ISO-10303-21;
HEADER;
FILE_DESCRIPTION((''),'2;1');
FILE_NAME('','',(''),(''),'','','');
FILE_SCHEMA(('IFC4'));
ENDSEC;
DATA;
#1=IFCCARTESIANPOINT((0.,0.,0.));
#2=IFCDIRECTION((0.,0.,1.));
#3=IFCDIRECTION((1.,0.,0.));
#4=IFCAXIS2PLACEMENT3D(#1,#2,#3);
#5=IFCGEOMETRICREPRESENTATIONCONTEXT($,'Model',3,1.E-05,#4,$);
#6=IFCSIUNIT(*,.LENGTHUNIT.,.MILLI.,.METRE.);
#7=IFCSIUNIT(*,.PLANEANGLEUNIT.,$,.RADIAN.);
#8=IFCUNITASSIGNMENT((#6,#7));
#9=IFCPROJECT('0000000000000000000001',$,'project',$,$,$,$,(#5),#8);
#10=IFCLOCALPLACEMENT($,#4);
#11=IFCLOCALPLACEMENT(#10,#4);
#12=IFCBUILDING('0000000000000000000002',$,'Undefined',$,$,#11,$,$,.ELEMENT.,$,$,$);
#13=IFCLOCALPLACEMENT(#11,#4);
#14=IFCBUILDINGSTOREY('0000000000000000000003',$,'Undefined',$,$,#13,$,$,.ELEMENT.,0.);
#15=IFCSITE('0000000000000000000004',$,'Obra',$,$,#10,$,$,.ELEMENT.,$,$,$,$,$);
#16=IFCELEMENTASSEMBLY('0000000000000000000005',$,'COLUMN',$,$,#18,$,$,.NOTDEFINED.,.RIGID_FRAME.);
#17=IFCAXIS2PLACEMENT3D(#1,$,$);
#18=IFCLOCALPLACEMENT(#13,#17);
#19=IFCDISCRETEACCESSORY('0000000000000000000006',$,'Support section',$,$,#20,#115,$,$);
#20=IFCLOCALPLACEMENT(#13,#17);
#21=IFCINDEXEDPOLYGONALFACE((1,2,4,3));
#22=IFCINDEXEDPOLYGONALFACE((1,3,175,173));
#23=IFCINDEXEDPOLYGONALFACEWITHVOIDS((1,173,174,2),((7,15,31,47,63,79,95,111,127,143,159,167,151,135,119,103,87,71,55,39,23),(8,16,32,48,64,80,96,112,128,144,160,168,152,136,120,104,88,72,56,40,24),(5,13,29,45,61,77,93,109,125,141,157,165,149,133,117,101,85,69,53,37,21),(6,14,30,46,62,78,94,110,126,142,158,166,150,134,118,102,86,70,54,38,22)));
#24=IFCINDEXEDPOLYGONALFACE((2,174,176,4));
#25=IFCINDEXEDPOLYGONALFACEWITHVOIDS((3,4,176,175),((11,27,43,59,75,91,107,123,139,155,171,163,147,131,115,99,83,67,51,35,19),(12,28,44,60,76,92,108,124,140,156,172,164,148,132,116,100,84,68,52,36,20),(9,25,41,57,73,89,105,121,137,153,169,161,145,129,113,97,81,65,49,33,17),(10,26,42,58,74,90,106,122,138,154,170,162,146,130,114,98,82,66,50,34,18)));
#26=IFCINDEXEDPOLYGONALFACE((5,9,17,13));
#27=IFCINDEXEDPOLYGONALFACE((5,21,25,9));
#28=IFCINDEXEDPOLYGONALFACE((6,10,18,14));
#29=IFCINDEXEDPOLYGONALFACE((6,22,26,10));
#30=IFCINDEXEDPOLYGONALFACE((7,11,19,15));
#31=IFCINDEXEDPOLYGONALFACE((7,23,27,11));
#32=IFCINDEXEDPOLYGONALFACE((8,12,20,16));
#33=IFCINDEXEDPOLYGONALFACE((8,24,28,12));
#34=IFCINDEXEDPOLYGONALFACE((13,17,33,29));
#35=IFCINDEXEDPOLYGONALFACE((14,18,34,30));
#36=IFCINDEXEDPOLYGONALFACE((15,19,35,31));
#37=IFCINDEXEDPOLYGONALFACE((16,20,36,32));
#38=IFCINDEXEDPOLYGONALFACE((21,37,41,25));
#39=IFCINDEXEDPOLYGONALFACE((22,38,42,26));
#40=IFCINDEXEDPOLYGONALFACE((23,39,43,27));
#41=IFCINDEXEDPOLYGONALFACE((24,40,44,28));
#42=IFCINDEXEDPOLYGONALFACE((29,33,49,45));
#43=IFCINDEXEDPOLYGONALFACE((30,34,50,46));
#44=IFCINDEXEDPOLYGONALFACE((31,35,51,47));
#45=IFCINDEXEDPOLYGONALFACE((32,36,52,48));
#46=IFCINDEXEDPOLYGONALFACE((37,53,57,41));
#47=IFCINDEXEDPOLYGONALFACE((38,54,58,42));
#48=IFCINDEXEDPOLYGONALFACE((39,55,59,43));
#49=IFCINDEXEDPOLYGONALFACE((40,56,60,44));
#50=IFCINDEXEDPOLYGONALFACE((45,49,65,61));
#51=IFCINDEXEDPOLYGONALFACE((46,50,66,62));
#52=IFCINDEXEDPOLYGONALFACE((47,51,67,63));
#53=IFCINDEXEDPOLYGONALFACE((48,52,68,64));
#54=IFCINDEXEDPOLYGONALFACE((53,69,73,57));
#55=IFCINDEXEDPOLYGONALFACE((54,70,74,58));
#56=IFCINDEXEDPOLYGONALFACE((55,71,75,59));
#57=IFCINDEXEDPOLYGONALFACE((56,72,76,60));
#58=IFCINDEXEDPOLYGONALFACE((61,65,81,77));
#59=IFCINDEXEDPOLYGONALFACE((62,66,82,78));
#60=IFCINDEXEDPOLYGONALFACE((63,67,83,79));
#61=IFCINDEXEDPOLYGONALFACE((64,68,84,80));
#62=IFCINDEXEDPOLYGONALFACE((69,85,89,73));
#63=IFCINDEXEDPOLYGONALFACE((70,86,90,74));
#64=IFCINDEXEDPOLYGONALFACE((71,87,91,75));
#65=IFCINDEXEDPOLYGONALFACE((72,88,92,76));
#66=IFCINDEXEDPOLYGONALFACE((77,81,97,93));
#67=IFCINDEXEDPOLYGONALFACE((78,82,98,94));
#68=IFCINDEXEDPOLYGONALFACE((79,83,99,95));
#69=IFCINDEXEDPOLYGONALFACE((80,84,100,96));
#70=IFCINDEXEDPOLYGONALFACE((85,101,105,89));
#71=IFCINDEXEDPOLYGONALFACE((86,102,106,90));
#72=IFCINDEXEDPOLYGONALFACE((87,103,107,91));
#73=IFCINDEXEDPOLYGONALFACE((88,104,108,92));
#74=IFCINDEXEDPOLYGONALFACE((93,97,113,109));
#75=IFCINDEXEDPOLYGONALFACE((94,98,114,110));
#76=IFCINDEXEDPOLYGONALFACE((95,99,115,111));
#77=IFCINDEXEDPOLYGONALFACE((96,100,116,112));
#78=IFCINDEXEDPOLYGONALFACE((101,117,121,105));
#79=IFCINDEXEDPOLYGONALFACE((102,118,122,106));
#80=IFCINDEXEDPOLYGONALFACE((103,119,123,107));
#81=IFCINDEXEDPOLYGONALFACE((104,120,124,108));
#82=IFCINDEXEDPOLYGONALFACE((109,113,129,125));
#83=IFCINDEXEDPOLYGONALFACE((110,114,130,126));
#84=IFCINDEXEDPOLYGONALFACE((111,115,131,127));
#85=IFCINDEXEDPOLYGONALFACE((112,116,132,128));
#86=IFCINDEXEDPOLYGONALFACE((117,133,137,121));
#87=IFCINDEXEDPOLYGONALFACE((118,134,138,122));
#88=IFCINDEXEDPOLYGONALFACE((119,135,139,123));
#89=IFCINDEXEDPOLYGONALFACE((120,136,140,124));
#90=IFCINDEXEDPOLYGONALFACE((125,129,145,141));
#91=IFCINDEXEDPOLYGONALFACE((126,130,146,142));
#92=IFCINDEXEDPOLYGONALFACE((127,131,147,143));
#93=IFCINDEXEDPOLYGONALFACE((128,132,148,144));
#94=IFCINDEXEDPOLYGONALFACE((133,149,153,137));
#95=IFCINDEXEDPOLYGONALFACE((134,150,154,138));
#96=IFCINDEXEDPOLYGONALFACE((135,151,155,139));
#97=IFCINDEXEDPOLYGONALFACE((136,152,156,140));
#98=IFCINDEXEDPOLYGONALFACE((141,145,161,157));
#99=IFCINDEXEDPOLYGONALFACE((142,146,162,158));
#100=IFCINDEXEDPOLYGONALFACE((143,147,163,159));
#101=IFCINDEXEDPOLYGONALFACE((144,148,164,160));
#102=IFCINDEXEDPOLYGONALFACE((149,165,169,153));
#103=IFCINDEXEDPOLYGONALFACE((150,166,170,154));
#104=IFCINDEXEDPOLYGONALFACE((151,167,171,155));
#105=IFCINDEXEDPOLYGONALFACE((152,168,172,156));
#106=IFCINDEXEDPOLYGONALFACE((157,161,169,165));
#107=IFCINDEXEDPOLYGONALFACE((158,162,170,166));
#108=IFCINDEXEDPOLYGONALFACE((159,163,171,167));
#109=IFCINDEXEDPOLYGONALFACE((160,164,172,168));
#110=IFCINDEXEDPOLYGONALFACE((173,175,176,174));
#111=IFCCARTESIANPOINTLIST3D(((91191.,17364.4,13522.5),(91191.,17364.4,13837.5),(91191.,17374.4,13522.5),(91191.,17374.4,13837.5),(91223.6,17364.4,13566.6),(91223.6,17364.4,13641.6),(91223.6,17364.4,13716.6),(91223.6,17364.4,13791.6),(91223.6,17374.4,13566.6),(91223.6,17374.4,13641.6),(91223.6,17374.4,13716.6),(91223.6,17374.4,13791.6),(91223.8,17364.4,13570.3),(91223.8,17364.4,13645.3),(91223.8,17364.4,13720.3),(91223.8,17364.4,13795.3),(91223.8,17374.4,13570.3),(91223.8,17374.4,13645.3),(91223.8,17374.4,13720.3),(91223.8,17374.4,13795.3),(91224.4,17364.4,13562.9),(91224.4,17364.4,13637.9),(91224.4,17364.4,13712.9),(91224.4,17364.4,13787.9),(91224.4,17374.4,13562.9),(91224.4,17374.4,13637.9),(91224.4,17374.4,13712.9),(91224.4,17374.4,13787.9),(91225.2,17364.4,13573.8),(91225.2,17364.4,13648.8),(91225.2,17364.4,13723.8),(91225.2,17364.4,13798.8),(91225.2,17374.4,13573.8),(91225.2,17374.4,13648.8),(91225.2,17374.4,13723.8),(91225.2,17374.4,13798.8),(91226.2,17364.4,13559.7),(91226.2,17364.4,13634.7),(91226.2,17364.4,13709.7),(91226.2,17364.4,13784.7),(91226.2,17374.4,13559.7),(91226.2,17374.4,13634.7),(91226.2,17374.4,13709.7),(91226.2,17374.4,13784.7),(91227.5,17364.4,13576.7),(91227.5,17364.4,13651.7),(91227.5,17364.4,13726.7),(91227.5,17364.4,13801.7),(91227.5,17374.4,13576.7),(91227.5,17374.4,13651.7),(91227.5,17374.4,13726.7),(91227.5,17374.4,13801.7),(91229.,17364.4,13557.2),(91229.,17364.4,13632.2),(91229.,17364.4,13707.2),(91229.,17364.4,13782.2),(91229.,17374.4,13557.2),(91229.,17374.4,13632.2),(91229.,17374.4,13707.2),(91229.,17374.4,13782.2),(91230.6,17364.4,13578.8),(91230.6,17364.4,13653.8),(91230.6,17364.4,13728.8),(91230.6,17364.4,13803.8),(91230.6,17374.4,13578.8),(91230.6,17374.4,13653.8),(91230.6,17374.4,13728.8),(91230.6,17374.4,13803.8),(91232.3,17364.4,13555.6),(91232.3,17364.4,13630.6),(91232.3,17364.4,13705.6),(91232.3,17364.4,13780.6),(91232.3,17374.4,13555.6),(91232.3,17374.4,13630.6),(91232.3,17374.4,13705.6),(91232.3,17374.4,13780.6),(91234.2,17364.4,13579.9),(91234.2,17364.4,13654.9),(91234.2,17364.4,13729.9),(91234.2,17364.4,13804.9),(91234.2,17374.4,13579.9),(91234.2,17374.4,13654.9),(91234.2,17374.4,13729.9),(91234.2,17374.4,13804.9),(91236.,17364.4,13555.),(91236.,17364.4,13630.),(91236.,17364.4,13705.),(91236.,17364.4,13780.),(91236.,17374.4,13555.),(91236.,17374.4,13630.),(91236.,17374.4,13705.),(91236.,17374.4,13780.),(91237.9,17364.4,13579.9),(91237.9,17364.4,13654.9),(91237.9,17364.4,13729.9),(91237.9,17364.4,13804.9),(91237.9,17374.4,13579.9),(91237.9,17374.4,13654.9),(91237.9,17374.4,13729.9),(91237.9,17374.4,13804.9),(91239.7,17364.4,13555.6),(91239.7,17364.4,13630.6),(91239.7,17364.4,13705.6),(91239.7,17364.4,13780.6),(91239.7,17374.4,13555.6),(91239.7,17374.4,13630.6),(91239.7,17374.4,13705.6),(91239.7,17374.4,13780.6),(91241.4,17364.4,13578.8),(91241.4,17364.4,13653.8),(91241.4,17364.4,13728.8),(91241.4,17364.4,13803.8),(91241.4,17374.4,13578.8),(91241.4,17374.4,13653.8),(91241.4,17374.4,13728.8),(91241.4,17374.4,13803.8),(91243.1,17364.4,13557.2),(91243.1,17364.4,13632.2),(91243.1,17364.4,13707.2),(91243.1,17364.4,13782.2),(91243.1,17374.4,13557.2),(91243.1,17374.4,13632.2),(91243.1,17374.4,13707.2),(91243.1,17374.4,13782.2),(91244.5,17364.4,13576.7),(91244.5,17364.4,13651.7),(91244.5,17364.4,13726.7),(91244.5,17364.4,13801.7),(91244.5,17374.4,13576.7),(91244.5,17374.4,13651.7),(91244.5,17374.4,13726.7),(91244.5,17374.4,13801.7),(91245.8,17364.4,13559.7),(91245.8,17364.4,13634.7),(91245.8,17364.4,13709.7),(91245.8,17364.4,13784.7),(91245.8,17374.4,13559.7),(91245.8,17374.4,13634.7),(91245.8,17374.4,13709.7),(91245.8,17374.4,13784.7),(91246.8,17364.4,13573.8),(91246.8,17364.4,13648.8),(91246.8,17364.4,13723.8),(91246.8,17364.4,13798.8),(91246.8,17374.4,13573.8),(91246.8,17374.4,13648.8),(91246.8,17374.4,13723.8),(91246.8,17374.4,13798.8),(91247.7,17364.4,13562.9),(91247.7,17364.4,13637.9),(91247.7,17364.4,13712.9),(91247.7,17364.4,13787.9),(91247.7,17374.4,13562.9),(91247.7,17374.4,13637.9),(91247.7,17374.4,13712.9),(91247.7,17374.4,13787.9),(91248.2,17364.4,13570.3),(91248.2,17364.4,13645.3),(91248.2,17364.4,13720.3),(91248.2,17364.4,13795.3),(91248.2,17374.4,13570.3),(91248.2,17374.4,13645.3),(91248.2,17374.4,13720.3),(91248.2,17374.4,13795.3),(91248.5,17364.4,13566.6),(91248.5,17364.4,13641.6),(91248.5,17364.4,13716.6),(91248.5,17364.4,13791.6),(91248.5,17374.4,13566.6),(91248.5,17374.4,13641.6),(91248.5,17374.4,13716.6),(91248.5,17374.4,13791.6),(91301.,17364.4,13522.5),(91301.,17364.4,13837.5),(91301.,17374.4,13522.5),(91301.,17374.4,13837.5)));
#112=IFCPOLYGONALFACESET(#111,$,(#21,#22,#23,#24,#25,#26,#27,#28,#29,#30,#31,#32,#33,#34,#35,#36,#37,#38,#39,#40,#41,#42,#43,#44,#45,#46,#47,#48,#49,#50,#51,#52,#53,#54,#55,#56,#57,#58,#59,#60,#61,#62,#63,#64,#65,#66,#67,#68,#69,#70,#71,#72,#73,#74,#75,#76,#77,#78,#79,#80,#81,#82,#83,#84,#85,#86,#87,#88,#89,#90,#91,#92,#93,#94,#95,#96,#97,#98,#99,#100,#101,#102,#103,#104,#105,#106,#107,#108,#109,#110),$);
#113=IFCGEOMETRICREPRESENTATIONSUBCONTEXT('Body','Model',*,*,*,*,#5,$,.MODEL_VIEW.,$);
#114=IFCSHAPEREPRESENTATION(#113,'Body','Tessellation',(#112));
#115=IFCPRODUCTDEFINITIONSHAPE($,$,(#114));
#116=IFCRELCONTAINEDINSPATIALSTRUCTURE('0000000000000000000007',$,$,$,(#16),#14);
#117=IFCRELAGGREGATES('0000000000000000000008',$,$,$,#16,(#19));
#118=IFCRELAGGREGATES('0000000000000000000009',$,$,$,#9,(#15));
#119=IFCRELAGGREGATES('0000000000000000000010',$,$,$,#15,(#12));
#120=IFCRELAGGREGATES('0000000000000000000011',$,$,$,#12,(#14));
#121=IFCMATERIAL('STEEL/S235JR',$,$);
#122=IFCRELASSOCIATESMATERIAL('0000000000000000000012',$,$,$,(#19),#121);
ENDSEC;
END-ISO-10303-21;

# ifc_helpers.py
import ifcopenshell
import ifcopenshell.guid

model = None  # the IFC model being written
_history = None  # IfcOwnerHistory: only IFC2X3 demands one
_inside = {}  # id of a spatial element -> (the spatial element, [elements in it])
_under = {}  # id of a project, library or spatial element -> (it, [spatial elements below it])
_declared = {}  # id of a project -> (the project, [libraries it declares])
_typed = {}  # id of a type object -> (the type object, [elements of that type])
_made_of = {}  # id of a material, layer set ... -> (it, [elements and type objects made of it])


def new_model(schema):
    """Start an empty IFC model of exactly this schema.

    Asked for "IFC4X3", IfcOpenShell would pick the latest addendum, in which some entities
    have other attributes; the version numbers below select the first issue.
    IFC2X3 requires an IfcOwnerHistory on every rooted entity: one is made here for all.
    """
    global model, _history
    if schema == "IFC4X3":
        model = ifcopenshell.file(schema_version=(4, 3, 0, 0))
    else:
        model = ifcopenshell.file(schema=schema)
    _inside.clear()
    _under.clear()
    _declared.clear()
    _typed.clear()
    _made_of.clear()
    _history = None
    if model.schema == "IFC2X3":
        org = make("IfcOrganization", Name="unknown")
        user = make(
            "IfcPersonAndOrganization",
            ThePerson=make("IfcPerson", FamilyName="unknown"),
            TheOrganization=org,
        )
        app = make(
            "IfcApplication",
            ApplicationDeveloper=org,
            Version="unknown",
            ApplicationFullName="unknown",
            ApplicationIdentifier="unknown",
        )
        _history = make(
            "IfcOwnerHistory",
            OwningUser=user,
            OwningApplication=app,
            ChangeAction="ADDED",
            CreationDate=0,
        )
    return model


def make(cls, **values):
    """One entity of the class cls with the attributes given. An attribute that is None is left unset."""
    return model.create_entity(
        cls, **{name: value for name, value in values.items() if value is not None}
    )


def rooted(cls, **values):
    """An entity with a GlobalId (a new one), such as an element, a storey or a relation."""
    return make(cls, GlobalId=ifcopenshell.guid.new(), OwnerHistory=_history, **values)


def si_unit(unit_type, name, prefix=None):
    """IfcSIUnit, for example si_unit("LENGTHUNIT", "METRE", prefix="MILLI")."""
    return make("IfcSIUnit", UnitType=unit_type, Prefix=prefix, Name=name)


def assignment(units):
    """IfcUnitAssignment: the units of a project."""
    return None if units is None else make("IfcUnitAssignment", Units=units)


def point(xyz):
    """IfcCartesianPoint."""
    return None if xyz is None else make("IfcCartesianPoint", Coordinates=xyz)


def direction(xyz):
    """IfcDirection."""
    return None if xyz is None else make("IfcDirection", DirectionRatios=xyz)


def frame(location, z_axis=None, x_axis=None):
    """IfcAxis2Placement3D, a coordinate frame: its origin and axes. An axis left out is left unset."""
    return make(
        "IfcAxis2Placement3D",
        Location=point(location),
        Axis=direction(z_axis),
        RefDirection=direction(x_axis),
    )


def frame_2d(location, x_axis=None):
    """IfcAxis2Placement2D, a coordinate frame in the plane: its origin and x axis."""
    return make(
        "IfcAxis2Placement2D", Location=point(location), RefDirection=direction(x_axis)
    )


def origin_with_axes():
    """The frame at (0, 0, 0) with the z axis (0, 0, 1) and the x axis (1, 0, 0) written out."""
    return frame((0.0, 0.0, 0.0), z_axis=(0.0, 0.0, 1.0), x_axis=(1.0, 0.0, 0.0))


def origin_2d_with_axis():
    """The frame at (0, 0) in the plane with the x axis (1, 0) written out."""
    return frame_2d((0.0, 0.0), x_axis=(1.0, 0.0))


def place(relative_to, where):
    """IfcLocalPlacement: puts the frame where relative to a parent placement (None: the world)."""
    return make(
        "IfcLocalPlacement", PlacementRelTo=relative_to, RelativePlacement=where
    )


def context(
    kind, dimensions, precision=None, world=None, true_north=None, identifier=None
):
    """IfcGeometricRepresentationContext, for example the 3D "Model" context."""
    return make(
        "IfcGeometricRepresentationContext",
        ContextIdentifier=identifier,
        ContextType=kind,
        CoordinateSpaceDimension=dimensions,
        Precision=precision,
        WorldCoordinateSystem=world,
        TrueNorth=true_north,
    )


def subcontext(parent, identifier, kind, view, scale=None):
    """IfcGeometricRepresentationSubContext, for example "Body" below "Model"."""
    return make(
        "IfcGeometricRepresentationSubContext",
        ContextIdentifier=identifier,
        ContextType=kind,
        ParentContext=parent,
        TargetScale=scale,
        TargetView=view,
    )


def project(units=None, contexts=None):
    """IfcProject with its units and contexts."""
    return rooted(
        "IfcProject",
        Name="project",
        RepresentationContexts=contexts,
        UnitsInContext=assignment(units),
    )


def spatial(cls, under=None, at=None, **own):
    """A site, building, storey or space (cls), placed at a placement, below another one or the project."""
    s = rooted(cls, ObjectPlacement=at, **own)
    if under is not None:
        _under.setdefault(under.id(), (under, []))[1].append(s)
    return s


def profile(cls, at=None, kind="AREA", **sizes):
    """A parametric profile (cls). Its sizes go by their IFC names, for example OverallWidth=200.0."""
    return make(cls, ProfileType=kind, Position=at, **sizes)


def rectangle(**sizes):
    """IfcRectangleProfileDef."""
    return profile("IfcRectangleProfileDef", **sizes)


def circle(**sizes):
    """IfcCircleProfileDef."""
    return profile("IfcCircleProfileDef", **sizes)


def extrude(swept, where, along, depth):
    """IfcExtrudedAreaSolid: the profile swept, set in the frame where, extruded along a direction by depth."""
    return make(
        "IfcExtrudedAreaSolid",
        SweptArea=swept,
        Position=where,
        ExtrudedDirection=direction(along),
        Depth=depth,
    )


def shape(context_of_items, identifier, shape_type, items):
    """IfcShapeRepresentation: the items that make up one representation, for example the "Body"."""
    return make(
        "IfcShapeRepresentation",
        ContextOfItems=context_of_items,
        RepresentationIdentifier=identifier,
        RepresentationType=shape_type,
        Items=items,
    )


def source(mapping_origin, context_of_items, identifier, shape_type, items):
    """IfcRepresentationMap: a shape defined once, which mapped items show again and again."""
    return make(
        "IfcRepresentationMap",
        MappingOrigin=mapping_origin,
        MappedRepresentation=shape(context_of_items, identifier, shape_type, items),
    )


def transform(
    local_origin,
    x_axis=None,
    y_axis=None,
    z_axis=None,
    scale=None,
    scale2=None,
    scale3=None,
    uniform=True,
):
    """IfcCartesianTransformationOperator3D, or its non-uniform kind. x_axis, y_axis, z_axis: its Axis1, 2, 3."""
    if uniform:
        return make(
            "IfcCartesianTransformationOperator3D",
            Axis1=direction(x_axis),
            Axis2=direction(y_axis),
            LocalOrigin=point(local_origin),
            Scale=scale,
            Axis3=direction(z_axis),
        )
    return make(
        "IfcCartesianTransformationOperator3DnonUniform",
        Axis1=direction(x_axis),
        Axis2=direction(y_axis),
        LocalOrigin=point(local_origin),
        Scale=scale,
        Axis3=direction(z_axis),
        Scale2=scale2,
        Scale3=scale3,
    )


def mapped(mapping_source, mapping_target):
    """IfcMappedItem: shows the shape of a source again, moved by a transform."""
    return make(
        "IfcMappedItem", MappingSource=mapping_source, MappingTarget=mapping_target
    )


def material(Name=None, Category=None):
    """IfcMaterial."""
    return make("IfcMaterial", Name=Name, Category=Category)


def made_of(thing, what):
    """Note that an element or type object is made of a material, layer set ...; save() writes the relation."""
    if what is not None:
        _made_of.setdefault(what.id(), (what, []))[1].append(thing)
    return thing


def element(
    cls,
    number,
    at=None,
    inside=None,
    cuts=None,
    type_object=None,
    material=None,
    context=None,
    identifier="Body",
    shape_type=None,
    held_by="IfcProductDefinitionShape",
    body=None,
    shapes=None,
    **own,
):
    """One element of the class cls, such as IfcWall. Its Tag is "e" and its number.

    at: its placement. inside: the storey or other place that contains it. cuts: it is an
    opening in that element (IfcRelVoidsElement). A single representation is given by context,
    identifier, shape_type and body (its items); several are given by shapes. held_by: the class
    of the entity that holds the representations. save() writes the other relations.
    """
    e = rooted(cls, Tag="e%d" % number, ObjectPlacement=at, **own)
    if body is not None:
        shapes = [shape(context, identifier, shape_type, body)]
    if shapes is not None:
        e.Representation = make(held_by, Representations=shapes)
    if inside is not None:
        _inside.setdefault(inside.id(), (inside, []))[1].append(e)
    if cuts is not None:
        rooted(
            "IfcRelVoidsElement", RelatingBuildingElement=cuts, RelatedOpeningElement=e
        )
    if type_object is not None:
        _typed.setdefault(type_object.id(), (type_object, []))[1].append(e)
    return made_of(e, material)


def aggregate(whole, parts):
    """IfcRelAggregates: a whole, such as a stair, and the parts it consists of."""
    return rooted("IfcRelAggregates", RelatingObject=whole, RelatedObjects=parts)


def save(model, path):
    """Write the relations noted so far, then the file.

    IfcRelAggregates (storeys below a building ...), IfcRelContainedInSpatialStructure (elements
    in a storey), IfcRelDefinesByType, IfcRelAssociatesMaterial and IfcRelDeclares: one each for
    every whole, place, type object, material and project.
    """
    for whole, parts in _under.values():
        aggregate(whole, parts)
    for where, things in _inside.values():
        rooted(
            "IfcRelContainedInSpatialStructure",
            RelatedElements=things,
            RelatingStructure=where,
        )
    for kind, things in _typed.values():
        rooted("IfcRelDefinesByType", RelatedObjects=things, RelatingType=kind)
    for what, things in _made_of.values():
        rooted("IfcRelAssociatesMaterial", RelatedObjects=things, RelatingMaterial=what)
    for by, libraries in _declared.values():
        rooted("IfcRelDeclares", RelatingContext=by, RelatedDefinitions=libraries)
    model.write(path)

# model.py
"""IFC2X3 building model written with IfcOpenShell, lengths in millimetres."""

from ifc_helpers import new_model, si_unit, frame, origin_with_axes, origin_2d_with_axis, place, context, subcontext, project, spatial, rectangle, circle, extrude, source, transform, mapped, material, element, aggregate, save


model = new_model("IFC2X3")

# Units and contexts
model_context = context("Model", 3, precision=1e-05, world=origin_with_axes())
body_context = subcontext(model_context, "Body", "Model", "MODEL_VIEW")
ifc_project = project(units=[si_unit("LENGTHUNIT", "METRE", prefix="MILLI"), si_unit("PLANEANGLEUNIT", "RADIAN")], contexts=[model_context])

# Site, building, storey
site_placement = place(None, origin_with_axes())
site = spatial("IfcSite", under=ifc_project, at=site_placement, Name="Obra", CompositionType="ELEMENT")
building_placement = place(site_placement, origin_with_axes())
building = spatial("IfcBuilding", under=site, at=building_placement, Name="Undefined", CompositionType="ELEMENT")
storey_placement = place(building_placement, origin_with_axes())
storey = spatial("IfcBuildingStorey", under=building, at=storey_placement, Name="Undefined", CompositionType="ELEMENT", Elevation=0.0)

# Element assembly
assembly_1_placement = place(storey_placement, origin_with_axes())
assembly_1 = element("IfcElementAssembly", 1, at=assembly_1_placement, inside=storey, Name="COLUMN", AssemblyPlace="NOTDEFINED", PredefinedType="RIGID_FRAME")
ifc_material_1 = material(Name="STEEL/S235JR")

# Discrete accessory, opening
discrete_accessory_1_placement = place(assembly_1_placement, frame((91246.0, 17369.4, 13522.5), z_axis=(0.0, 0.0, 1.0), x_axis=(1.0, 0.0, 0.0)))
discrete_accessory_1 = element("IfcDiscreteAccessory", 2, at=discrete_accessory_1_placement, material=ifc_material_1, Name="Support section", context=body_context, shape_type="SweptSolid", body=[
    extrude(rectangle(XDim=10.0, YDim=110.0, at=origin_2d_with_axis()), frame((0.0, 0.0, 315.0), z_axis=(0.0, 0.0, -1.0), x_axis=(0.0, 1.0, 0.0)), (0.0, 0.0, 1.0), 315.0),
])
shared_shape_1 = source(origin_with_axes(), body_context, "Body", "SweptSolid", [
    extrude(circle(Radius=12.5, at=origin_2d_with_axis()), frame((0.0, 5.7, 0.0), z_axis=(0.0, 1.0, 0.0), x_axis=(1.0, 0.0, 0.0)), (0.0, 0.0, 1.0), 10.2),
])
opening_1_placement = place(assembly_1_placement, frame((91281.0, 17380.1, 13900.0), z_axis=(-1.0, 0.0, 0.0), x_axis=(0.0, 0.0, -1.0)))
element("IfcOpeningElement", 3, at=opening_1_placement, cuts=discrete_accessory_1, ObjectType="Opening", context=body_context, shape_type="MappedRepresentation", body=[
    mapped(shared_shape_1, transform((107.5, 0.0, 45.0))),
    mapped(shared_shape_1, transform((182.5, 0.0, 45.0))),
    mapped(shared_shape_1, transform((257.5, 0.0, 45.0))),
    mapped(shared_shape_1, transform((332.5, 0.0, 45.0))),
])
aggregate(assembly_1, [discrete_accessory_1])

save(model, "model.ifc")
